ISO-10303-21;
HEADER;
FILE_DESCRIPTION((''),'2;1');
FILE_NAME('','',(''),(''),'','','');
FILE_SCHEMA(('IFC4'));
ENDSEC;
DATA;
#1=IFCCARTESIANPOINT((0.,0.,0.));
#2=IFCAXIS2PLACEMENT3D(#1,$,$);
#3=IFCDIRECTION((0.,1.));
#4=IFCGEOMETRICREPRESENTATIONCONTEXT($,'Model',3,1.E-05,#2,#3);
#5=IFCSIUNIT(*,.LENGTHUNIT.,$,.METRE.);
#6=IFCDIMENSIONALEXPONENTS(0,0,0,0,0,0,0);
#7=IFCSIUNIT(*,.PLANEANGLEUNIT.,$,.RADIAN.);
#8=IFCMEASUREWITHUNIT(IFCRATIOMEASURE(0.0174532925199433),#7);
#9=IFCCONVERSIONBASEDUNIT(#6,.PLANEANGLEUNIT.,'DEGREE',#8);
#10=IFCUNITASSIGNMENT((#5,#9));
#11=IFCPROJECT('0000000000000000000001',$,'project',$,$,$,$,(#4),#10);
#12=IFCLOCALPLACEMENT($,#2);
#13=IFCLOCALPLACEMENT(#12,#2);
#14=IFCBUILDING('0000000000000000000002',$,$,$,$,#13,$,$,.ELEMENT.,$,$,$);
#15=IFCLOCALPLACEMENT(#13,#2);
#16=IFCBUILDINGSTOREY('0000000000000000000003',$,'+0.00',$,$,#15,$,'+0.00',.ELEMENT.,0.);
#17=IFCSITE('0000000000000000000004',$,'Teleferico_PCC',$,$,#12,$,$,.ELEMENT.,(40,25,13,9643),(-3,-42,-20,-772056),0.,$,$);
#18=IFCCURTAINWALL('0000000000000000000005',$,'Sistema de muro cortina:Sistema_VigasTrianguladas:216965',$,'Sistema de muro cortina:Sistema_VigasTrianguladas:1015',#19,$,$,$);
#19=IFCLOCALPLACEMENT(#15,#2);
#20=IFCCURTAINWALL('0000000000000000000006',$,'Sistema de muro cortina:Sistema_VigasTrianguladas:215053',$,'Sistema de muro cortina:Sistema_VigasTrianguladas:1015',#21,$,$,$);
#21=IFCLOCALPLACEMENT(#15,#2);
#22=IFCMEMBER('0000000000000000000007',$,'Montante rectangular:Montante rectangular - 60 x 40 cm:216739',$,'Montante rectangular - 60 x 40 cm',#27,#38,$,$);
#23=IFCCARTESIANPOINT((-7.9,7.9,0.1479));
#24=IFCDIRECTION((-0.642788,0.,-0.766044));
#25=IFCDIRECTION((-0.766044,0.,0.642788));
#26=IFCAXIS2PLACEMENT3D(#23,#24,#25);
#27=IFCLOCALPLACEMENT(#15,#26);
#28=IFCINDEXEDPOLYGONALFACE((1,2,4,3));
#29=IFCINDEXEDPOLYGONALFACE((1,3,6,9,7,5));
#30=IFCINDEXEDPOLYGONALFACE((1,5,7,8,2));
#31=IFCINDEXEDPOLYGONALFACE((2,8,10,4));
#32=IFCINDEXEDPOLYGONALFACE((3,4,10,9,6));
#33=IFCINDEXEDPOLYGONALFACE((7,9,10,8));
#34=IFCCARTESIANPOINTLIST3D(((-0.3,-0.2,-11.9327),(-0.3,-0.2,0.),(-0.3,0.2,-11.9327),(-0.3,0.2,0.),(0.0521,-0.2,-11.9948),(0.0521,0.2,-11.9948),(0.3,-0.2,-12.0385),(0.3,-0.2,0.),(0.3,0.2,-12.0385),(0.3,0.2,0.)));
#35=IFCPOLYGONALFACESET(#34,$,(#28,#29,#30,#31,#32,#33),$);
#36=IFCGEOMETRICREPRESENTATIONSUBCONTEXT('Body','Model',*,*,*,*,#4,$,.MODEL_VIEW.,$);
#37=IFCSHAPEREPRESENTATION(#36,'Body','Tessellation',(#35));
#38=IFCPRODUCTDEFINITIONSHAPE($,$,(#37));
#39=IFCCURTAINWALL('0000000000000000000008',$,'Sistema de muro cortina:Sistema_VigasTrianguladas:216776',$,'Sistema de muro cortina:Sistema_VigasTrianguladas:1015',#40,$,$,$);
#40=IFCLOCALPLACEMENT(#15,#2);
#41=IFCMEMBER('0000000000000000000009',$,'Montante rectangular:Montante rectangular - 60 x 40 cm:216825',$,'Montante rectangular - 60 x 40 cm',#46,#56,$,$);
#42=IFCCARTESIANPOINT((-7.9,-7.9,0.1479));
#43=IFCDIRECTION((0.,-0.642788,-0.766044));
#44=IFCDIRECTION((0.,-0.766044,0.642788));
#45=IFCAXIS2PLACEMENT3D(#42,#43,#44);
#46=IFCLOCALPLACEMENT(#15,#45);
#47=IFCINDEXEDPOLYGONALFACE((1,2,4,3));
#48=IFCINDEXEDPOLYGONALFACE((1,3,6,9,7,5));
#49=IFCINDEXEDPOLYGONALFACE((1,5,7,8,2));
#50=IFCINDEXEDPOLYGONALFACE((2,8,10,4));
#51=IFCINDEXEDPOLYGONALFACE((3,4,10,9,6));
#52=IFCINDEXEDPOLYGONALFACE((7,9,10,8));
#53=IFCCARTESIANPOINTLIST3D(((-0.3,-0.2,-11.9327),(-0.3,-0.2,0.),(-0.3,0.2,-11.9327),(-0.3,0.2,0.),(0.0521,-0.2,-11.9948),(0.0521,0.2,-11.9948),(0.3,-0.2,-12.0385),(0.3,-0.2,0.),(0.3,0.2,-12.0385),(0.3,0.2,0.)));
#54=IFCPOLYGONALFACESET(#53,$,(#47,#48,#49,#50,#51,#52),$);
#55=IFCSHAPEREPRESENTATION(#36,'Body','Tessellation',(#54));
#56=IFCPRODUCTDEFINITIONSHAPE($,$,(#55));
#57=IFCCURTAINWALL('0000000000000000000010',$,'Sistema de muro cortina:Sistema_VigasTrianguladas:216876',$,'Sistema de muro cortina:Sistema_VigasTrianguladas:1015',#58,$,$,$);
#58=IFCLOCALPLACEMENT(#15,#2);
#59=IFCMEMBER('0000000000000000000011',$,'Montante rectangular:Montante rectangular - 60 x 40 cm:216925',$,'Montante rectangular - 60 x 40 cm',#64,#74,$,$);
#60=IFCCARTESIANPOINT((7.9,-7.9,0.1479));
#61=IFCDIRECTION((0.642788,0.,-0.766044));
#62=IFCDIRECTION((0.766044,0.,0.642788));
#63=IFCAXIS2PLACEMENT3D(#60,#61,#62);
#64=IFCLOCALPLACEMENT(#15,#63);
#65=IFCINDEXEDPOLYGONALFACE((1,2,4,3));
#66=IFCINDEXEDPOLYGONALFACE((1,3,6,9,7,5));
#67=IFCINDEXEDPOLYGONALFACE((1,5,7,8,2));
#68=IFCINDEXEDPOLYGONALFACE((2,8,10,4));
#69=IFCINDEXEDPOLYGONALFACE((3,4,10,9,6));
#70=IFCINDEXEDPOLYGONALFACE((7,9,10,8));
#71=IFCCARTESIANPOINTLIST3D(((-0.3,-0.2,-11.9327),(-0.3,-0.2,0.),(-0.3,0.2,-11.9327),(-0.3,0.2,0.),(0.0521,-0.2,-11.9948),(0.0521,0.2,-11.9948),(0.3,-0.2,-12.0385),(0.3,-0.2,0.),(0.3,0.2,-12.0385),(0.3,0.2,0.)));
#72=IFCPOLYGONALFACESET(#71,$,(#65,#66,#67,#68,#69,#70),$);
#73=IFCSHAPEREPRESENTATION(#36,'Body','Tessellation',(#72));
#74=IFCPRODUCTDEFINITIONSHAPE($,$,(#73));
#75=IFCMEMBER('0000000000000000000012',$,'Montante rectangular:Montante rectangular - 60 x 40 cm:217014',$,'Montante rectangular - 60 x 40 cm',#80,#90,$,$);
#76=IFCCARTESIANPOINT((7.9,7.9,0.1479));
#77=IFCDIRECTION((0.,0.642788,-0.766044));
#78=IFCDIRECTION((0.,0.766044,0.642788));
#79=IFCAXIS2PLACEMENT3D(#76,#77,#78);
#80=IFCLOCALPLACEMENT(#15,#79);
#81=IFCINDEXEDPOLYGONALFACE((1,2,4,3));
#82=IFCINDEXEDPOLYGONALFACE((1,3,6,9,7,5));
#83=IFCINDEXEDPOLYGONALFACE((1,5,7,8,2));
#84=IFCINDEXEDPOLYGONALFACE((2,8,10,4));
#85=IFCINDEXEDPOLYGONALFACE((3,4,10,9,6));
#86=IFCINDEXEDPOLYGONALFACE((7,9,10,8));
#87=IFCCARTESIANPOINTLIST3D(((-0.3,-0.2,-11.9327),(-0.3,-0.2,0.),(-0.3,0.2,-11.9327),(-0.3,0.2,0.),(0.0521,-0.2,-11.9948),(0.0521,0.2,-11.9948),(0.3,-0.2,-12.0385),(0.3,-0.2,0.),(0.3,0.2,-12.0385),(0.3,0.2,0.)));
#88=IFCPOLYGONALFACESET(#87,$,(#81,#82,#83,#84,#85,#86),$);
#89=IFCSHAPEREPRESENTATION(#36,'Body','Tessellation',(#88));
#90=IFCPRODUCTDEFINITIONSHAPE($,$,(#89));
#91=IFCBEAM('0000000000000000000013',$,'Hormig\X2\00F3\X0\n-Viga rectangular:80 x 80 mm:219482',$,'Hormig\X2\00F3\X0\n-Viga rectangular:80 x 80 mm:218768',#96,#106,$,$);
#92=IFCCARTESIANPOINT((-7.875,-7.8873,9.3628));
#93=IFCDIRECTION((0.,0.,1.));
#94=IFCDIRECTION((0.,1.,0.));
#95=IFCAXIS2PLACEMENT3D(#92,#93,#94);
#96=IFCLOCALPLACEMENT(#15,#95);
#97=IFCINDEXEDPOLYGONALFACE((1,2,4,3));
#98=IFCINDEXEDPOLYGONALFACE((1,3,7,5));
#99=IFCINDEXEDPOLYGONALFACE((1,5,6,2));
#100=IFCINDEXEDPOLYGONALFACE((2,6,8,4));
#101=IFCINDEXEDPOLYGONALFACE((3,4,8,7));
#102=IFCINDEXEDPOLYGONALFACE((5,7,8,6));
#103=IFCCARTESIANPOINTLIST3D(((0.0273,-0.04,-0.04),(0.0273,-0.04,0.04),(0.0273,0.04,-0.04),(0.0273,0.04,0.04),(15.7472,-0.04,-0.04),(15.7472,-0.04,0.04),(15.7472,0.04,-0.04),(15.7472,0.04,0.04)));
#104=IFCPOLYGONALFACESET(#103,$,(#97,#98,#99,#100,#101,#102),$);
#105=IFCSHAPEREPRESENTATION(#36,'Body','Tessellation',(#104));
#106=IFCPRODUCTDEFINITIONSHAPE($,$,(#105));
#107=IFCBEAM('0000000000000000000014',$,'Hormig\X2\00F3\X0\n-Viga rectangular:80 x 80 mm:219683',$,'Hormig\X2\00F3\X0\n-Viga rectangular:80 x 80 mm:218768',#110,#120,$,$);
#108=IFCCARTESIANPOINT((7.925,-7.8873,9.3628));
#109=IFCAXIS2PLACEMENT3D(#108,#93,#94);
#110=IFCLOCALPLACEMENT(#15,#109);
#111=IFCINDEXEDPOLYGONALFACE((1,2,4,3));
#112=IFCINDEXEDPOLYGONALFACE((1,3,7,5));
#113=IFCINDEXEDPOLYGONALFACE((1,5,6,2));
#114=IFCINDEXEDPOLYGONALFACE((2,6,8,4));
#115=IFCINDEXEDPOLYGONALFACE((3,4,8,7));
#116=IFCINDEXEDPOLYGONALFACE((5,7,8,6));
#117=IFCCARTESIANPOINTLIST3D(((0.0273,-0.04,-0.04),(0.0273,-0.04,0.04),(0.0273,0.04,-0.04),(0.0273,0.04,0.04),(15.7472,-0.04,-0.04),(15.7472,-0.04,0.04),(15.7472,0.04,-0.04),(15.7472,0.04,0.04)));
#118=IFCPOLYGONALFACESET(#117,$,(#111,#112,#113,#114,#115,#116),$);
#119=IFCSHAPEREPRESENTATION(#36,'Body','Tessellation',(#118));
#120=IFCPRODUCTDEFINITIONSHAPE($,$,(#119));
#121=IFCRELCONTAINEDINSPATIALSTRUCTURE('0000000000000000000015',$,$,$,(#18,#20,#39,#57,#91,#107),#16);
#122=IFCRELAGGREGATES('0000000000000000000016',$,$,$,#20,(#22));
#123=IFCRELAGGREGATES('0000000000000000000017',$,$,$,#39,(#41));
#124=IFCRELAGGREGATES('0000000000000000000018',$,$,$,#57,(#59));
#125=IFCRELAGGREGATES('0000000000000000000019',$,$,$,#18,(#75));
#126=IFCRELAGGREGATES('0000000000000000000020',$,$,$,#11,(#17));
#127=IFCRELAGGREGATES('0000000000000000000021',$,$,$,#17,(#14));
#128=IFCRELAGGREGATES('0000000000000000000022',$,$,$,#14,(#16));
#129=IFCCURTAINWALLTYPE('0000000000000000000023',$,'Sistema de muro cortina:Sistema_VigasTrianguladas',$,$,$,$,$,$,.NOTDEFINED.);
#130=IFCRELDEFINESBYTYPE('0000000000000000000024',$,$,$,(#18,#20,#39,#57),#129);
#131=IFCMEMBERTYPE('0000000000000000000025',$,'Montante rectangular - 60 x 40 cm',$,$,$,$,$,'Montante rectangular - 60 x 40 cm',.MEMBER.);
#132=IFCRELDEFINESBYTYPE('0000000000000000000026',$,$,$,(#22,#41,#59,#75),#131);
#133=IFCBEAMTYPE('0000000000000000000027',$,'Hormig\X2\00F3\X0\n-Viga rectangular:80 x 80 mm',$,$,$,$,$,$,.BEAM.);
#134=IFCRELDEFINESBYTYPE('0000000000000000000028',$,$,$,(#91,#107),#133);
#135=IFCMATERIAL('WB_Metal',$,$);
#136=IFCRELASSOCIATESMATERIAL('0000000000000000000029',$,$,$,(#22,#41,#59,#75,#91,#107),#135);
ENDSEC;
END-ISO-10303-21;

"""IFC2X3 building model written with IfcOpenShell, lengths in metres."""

from ifc_helpers import new_model, entity, si_unit, converted_unit, direction, frame, frame_2d, origin, origin_2d_with_axis, place, context, subcontext, project, spatial, polyline, rectangle, extrude, clip, bounded_halfspace, source, transform, mapped, material, type_object, type_shapes, element, aggregate, save


model = new_model("IFC2X3")

# Units and contexts
model_context = context("Model", 3, precision=1e-05, world=origin(), true_north=direction((0.0, 1.0)))
body_context = subcontext(model_context, "Body", "Model", "MODEL_VIEW")
ifc_project = project(units=[si_unit("LENGTHUNIT", "METRE"), converted_unit("PLANEANGLEUNIT", "DEGREE", entity("IfcRatioMeasure", 0.0174532925199433), si_unit("PLANEANGLEUNIT", "RADIAN"), dimensions=[0, 0, 0, 0, 0, 0, 0])], contexts=[model_context])

# Site, building, storey
site_placement = place(None, origin())
site = spatial("IfcSite", under=ifc_project, at=site_placement, Name="Teleferico_PCC", CompositionType="ELEMENT", RefLatitude=(40, 25, 13, 9643), RefLongitude=(-3, -42, -20, -772056), RefElevation=0.0)
building_placement = place(site_placement, origin())
building = spatial("IfcBuilding", under=site, at=building_placement, CompositionType="ELEMENT")
storey_placement = place(building_placement, origin())
storey = spatial("IfcBuildingStorey", under=building, at=storey_placement, Name="+0.00", LongName="+0.00", CompositionType="ELEMENT", Elevation=0.0)

# Shared definitions
ifc_material_1 = material(Name="WB_Metal")

# Curtain walls, members
curtain_wall_type = type_object("IfcCurtainWallType", Name="Sistema de muro cortina:Sistema_VigasTrianguladas", PredefinedType="NOTDEFINED")
curtain_wall_1_placement = place(storey_placement, origin())
curtain_wall_1 = element("IfcCurtainWall", 1, at=curtain_wall_1_placement, inside=storey, type_object=curtain_wall_type, Name="Sistema de muro cortina:Sistema_VigasTrianguladas:216965", ObjectType="Sistema de muro cortina:Sistema_VigasTrianguladas:1015")
curtain_wall_2_placement = place(storey_placement, origin())
curtain_wall_2 = element("IfcCurtainWall", 2, at=curtain_wall_2_placement, inside=storey, type_object=curtain_wall_type, Name="Sistema de muro cortina:Sistema_VigasTrianguladas:215053", ObjectType="Sistema de muro cortina:Sistema_VigasTrianguladas:1015")
member_type_1 = type_object("IfcMemberType", Name="Montante rectangular - 60 x 40 cm", ElementType="Montante rectangular - 60 x 40 cm", PredefinedType="MEMBER")
shared_shape_1 = source(origin(), body_context, "Body", "Clipping", [
    clip(clip(extrude(rectangle(XDim=0.4, YDim=0.6, at=origin_2d_with_axis()), frame((0.0, 0.0, -12.0385), z_axis=(0.0, 0.0, 1.0), x_axis=(0.0, -1.0, 0.0)), (0.0, 0.0, 1.0), 12.0385), bounded_halfspace(frame((12.1556, 91.44, -14.1289), z_axis=(-0.173648, 0.0, -0.984808), x_axis=(-0.984808, 0.0, 0.173648)), False, frame((0.0, 0.0, -12.0385), z_axis=(0.0, 0.0, 1.0), x_axis=(0.0, -1.0, 0.0)), polyline([(0.2, 0.3), (0.2, 0.0521), (-0.2, 0.0521), (-0.2, 0.3), (0.2, 0.3)]))), bounded_halfspace(frame((0.0521, 91.44, -11.9948), z_axis=(-0.173648, 0.0, -0.984808), x_axis=(-0.984808, 0.0, 0.173648)), False, frame((0.0, 0.0, -12.0385), z_axis=(0.0, 0.0, 1.0), x_axis=(0.0, -1.0, 0.0)), polyline([(0.2, 0.0521), (0.2, -0.3), (-0.2, -0.3), (-0.2, 0.0521), (0.2, 0.0521)]))),
])
type_shapes(member_type_1, [shared_shape_1])
member_1_placement = place(storey_placement, frame((-7.9, 7.9, 0.1479), z_axis=(-0.642788, 0.0, -0.766044), x_axis=(-0.766044, 0.0, 0.642788)))
member_1 = element("IfcMember", 3, at=member_1_placement, type_object=member_type_1, material=ifc_material_1, Name="Montante rectangular:Montante rectangular - 60 x 40 cm:216739", ObjectType="Montante rectangular - 60 x 40 cm", context=body_context, shape_type="MappedRepresentation", body=[
    mapped(shared_shape_1, transform((0.0, 0.0, 0.0), scale=1.0)),
])
aggregate(curtain_wall_2, [member_1])
curtain_wall_3_placement = place(storey_placement, origin())
curtain_wall_3 = element("IfcCurtainWall", 4, at=curtain_wall_3_placement, inside=storey, type_object=curtain_wall_type, Name="Sistema de muro cortina:Sistema_VigasTrianguladas:216776", ObjectType="Sistema de muro cortina:Sistema_VigasTrianguladas:1015")
member_2_placement = place(storey_placement, frame((-7.9, -7.9, 0.1479), z_axis=(0.0, -0.642788, -0.766044), x_axis=(0.0, -0.766044, 0.642788)))
member_2 = element("IfcMember", 5, at=member_2_placement, type_object=member_type_1, material=ifc_material_1, Name="Montante rectangular:Montante rectangular - 60 x 40 cm:216825", ObjectType="Montante rectangular - 60 x 40 cm", context=body_context, shape_type="MappedRepresentation", body=[
    mapped(shared_shape_1, transform((0.0, 0.0, 0.0), scale=1.0)),
])
aggregate(curtain_wall_3, [member_2])
curtain_wall_4_placement = place(storey_placement, origin())
curtain_wall_4 = element("IfcCurtainWall", 6, at=curtain_wall_4_placement, inside=storey, type_object=curtain_wall_type, Name="Sistema de muro cortina:Sistema_VigasTrianguladas:216876", ObjectType="Sistema de muro cortina:Sistema_VigasTrianguladas:1015")
member_3_placement = place(storey_placement, frame((7.9, -7.9, 0.1479), z_axis=(0.642788, 0.0, -0.766044), x_axis=(0.766044, 0.0, 0.642788)))
member_3 = element("IfcMember", 7, at=member_3_placement, type_object=member_type_1, material=ifc_material_1, Name="Montante rectangular:Montante rectangular - 60 x 40 cm:216925", ObjectType="Montante rectangular - 60 x 40 cm", context=body_context, shape_type="MappedRepresentation", body=[
    mapped(shared_shape_1, transform((0.0, 0.0, 0.0), scale=1.0)),
])
aggregate(curtain_wall_4, [member_3])

# Member
member_4_placement = place(storey_placement, frame((7.9, 7.9, 0.1479), z_axis=(0.0, 0.642788, -0.766044), x_axis=(0.0, 0.766044, 0.642788)))
member_4 = element("IfcMember", 8, at=member_4_placement, type_object=member_type_1, material=ifc_material_1, Name="Montante rectangular:Montante rectangular - 60 x 40 cm:217014", ObjectType="Montante rectangular - 60 x 40 cm", context=body_context, shape_type="MappedRepresentation", body=[
    mapped(shared_shape_1, transform((0.0, 0.0, 0.0), scale=1.0)),
])
aggregate(curtain_wall_1, [member_4])

# Beams
beam_type = type_object("IfcBeamType", Name="Hormigón-Viga rectangular:80 x 80 mm", PredefinedType="BEAM")
beam_1_placement = place(storey_placement, frame((-7.875, -7.8873, 9.3628), z_axis=(0.0, 0.0, 1.0), x_axis=(0.0, 1.0, 0.0)))
element("IfcBeam", 9, at=beam_1_placement, inside=storey, type_object=beam_type, material=ifc_material_1, Name="Hormigón-Viga rectangular:80 x 80 mm:219482", ObjectType="Hormigón-Viga rectangular:80 x 80 mm:218768", context=body_context, shape_type="SweptSolid", body=[
    extrude(rectangle(XDim=0.08, YDim=0.08, at=frame_2d((0.0, 0.0), x_axis=(1.0, 0.0))), frame((0.0273, 0.0, 0.0), z_axis=(1.0, 0.0, 0.0), x_axis=(0.0, 0.0, -1.0)), (0.0, 0.0, 1.0), 15.7199),
])
beam_2_placement = place(storey_placement, frame((7.925, -7.8873, 9.3628), z_axis=(0.0, 0.0, 1.0), x_axis=(0.0, 1.0, 0.0)))
element("IfcBeam", 10, at=beam_2_placement, inside=storey, type_object=beam_type, material=ifc_material_1, Name="Hormigón-Viga rectangular:80 x 80 mm:219683", ObjectType="Hormigón-Viga rectangular:80 x 80 mm:218768", context=body_context, shape_type="SweptSolid", body=[
    extrude(rectangle(XDim=0.08, YDim=0.08, at=frame_2d((0.0, 0.0), x_axis=(1.0, 0.0))), frame((0.0273, 0.0, 0.0), z_axis=(1.0, 0.0, 0.0), x_axis=(0.0, 0.0, -1.0)), (0.0, 0.0, 1.0), 15.7199),
])

save(model, "model.ifc")
